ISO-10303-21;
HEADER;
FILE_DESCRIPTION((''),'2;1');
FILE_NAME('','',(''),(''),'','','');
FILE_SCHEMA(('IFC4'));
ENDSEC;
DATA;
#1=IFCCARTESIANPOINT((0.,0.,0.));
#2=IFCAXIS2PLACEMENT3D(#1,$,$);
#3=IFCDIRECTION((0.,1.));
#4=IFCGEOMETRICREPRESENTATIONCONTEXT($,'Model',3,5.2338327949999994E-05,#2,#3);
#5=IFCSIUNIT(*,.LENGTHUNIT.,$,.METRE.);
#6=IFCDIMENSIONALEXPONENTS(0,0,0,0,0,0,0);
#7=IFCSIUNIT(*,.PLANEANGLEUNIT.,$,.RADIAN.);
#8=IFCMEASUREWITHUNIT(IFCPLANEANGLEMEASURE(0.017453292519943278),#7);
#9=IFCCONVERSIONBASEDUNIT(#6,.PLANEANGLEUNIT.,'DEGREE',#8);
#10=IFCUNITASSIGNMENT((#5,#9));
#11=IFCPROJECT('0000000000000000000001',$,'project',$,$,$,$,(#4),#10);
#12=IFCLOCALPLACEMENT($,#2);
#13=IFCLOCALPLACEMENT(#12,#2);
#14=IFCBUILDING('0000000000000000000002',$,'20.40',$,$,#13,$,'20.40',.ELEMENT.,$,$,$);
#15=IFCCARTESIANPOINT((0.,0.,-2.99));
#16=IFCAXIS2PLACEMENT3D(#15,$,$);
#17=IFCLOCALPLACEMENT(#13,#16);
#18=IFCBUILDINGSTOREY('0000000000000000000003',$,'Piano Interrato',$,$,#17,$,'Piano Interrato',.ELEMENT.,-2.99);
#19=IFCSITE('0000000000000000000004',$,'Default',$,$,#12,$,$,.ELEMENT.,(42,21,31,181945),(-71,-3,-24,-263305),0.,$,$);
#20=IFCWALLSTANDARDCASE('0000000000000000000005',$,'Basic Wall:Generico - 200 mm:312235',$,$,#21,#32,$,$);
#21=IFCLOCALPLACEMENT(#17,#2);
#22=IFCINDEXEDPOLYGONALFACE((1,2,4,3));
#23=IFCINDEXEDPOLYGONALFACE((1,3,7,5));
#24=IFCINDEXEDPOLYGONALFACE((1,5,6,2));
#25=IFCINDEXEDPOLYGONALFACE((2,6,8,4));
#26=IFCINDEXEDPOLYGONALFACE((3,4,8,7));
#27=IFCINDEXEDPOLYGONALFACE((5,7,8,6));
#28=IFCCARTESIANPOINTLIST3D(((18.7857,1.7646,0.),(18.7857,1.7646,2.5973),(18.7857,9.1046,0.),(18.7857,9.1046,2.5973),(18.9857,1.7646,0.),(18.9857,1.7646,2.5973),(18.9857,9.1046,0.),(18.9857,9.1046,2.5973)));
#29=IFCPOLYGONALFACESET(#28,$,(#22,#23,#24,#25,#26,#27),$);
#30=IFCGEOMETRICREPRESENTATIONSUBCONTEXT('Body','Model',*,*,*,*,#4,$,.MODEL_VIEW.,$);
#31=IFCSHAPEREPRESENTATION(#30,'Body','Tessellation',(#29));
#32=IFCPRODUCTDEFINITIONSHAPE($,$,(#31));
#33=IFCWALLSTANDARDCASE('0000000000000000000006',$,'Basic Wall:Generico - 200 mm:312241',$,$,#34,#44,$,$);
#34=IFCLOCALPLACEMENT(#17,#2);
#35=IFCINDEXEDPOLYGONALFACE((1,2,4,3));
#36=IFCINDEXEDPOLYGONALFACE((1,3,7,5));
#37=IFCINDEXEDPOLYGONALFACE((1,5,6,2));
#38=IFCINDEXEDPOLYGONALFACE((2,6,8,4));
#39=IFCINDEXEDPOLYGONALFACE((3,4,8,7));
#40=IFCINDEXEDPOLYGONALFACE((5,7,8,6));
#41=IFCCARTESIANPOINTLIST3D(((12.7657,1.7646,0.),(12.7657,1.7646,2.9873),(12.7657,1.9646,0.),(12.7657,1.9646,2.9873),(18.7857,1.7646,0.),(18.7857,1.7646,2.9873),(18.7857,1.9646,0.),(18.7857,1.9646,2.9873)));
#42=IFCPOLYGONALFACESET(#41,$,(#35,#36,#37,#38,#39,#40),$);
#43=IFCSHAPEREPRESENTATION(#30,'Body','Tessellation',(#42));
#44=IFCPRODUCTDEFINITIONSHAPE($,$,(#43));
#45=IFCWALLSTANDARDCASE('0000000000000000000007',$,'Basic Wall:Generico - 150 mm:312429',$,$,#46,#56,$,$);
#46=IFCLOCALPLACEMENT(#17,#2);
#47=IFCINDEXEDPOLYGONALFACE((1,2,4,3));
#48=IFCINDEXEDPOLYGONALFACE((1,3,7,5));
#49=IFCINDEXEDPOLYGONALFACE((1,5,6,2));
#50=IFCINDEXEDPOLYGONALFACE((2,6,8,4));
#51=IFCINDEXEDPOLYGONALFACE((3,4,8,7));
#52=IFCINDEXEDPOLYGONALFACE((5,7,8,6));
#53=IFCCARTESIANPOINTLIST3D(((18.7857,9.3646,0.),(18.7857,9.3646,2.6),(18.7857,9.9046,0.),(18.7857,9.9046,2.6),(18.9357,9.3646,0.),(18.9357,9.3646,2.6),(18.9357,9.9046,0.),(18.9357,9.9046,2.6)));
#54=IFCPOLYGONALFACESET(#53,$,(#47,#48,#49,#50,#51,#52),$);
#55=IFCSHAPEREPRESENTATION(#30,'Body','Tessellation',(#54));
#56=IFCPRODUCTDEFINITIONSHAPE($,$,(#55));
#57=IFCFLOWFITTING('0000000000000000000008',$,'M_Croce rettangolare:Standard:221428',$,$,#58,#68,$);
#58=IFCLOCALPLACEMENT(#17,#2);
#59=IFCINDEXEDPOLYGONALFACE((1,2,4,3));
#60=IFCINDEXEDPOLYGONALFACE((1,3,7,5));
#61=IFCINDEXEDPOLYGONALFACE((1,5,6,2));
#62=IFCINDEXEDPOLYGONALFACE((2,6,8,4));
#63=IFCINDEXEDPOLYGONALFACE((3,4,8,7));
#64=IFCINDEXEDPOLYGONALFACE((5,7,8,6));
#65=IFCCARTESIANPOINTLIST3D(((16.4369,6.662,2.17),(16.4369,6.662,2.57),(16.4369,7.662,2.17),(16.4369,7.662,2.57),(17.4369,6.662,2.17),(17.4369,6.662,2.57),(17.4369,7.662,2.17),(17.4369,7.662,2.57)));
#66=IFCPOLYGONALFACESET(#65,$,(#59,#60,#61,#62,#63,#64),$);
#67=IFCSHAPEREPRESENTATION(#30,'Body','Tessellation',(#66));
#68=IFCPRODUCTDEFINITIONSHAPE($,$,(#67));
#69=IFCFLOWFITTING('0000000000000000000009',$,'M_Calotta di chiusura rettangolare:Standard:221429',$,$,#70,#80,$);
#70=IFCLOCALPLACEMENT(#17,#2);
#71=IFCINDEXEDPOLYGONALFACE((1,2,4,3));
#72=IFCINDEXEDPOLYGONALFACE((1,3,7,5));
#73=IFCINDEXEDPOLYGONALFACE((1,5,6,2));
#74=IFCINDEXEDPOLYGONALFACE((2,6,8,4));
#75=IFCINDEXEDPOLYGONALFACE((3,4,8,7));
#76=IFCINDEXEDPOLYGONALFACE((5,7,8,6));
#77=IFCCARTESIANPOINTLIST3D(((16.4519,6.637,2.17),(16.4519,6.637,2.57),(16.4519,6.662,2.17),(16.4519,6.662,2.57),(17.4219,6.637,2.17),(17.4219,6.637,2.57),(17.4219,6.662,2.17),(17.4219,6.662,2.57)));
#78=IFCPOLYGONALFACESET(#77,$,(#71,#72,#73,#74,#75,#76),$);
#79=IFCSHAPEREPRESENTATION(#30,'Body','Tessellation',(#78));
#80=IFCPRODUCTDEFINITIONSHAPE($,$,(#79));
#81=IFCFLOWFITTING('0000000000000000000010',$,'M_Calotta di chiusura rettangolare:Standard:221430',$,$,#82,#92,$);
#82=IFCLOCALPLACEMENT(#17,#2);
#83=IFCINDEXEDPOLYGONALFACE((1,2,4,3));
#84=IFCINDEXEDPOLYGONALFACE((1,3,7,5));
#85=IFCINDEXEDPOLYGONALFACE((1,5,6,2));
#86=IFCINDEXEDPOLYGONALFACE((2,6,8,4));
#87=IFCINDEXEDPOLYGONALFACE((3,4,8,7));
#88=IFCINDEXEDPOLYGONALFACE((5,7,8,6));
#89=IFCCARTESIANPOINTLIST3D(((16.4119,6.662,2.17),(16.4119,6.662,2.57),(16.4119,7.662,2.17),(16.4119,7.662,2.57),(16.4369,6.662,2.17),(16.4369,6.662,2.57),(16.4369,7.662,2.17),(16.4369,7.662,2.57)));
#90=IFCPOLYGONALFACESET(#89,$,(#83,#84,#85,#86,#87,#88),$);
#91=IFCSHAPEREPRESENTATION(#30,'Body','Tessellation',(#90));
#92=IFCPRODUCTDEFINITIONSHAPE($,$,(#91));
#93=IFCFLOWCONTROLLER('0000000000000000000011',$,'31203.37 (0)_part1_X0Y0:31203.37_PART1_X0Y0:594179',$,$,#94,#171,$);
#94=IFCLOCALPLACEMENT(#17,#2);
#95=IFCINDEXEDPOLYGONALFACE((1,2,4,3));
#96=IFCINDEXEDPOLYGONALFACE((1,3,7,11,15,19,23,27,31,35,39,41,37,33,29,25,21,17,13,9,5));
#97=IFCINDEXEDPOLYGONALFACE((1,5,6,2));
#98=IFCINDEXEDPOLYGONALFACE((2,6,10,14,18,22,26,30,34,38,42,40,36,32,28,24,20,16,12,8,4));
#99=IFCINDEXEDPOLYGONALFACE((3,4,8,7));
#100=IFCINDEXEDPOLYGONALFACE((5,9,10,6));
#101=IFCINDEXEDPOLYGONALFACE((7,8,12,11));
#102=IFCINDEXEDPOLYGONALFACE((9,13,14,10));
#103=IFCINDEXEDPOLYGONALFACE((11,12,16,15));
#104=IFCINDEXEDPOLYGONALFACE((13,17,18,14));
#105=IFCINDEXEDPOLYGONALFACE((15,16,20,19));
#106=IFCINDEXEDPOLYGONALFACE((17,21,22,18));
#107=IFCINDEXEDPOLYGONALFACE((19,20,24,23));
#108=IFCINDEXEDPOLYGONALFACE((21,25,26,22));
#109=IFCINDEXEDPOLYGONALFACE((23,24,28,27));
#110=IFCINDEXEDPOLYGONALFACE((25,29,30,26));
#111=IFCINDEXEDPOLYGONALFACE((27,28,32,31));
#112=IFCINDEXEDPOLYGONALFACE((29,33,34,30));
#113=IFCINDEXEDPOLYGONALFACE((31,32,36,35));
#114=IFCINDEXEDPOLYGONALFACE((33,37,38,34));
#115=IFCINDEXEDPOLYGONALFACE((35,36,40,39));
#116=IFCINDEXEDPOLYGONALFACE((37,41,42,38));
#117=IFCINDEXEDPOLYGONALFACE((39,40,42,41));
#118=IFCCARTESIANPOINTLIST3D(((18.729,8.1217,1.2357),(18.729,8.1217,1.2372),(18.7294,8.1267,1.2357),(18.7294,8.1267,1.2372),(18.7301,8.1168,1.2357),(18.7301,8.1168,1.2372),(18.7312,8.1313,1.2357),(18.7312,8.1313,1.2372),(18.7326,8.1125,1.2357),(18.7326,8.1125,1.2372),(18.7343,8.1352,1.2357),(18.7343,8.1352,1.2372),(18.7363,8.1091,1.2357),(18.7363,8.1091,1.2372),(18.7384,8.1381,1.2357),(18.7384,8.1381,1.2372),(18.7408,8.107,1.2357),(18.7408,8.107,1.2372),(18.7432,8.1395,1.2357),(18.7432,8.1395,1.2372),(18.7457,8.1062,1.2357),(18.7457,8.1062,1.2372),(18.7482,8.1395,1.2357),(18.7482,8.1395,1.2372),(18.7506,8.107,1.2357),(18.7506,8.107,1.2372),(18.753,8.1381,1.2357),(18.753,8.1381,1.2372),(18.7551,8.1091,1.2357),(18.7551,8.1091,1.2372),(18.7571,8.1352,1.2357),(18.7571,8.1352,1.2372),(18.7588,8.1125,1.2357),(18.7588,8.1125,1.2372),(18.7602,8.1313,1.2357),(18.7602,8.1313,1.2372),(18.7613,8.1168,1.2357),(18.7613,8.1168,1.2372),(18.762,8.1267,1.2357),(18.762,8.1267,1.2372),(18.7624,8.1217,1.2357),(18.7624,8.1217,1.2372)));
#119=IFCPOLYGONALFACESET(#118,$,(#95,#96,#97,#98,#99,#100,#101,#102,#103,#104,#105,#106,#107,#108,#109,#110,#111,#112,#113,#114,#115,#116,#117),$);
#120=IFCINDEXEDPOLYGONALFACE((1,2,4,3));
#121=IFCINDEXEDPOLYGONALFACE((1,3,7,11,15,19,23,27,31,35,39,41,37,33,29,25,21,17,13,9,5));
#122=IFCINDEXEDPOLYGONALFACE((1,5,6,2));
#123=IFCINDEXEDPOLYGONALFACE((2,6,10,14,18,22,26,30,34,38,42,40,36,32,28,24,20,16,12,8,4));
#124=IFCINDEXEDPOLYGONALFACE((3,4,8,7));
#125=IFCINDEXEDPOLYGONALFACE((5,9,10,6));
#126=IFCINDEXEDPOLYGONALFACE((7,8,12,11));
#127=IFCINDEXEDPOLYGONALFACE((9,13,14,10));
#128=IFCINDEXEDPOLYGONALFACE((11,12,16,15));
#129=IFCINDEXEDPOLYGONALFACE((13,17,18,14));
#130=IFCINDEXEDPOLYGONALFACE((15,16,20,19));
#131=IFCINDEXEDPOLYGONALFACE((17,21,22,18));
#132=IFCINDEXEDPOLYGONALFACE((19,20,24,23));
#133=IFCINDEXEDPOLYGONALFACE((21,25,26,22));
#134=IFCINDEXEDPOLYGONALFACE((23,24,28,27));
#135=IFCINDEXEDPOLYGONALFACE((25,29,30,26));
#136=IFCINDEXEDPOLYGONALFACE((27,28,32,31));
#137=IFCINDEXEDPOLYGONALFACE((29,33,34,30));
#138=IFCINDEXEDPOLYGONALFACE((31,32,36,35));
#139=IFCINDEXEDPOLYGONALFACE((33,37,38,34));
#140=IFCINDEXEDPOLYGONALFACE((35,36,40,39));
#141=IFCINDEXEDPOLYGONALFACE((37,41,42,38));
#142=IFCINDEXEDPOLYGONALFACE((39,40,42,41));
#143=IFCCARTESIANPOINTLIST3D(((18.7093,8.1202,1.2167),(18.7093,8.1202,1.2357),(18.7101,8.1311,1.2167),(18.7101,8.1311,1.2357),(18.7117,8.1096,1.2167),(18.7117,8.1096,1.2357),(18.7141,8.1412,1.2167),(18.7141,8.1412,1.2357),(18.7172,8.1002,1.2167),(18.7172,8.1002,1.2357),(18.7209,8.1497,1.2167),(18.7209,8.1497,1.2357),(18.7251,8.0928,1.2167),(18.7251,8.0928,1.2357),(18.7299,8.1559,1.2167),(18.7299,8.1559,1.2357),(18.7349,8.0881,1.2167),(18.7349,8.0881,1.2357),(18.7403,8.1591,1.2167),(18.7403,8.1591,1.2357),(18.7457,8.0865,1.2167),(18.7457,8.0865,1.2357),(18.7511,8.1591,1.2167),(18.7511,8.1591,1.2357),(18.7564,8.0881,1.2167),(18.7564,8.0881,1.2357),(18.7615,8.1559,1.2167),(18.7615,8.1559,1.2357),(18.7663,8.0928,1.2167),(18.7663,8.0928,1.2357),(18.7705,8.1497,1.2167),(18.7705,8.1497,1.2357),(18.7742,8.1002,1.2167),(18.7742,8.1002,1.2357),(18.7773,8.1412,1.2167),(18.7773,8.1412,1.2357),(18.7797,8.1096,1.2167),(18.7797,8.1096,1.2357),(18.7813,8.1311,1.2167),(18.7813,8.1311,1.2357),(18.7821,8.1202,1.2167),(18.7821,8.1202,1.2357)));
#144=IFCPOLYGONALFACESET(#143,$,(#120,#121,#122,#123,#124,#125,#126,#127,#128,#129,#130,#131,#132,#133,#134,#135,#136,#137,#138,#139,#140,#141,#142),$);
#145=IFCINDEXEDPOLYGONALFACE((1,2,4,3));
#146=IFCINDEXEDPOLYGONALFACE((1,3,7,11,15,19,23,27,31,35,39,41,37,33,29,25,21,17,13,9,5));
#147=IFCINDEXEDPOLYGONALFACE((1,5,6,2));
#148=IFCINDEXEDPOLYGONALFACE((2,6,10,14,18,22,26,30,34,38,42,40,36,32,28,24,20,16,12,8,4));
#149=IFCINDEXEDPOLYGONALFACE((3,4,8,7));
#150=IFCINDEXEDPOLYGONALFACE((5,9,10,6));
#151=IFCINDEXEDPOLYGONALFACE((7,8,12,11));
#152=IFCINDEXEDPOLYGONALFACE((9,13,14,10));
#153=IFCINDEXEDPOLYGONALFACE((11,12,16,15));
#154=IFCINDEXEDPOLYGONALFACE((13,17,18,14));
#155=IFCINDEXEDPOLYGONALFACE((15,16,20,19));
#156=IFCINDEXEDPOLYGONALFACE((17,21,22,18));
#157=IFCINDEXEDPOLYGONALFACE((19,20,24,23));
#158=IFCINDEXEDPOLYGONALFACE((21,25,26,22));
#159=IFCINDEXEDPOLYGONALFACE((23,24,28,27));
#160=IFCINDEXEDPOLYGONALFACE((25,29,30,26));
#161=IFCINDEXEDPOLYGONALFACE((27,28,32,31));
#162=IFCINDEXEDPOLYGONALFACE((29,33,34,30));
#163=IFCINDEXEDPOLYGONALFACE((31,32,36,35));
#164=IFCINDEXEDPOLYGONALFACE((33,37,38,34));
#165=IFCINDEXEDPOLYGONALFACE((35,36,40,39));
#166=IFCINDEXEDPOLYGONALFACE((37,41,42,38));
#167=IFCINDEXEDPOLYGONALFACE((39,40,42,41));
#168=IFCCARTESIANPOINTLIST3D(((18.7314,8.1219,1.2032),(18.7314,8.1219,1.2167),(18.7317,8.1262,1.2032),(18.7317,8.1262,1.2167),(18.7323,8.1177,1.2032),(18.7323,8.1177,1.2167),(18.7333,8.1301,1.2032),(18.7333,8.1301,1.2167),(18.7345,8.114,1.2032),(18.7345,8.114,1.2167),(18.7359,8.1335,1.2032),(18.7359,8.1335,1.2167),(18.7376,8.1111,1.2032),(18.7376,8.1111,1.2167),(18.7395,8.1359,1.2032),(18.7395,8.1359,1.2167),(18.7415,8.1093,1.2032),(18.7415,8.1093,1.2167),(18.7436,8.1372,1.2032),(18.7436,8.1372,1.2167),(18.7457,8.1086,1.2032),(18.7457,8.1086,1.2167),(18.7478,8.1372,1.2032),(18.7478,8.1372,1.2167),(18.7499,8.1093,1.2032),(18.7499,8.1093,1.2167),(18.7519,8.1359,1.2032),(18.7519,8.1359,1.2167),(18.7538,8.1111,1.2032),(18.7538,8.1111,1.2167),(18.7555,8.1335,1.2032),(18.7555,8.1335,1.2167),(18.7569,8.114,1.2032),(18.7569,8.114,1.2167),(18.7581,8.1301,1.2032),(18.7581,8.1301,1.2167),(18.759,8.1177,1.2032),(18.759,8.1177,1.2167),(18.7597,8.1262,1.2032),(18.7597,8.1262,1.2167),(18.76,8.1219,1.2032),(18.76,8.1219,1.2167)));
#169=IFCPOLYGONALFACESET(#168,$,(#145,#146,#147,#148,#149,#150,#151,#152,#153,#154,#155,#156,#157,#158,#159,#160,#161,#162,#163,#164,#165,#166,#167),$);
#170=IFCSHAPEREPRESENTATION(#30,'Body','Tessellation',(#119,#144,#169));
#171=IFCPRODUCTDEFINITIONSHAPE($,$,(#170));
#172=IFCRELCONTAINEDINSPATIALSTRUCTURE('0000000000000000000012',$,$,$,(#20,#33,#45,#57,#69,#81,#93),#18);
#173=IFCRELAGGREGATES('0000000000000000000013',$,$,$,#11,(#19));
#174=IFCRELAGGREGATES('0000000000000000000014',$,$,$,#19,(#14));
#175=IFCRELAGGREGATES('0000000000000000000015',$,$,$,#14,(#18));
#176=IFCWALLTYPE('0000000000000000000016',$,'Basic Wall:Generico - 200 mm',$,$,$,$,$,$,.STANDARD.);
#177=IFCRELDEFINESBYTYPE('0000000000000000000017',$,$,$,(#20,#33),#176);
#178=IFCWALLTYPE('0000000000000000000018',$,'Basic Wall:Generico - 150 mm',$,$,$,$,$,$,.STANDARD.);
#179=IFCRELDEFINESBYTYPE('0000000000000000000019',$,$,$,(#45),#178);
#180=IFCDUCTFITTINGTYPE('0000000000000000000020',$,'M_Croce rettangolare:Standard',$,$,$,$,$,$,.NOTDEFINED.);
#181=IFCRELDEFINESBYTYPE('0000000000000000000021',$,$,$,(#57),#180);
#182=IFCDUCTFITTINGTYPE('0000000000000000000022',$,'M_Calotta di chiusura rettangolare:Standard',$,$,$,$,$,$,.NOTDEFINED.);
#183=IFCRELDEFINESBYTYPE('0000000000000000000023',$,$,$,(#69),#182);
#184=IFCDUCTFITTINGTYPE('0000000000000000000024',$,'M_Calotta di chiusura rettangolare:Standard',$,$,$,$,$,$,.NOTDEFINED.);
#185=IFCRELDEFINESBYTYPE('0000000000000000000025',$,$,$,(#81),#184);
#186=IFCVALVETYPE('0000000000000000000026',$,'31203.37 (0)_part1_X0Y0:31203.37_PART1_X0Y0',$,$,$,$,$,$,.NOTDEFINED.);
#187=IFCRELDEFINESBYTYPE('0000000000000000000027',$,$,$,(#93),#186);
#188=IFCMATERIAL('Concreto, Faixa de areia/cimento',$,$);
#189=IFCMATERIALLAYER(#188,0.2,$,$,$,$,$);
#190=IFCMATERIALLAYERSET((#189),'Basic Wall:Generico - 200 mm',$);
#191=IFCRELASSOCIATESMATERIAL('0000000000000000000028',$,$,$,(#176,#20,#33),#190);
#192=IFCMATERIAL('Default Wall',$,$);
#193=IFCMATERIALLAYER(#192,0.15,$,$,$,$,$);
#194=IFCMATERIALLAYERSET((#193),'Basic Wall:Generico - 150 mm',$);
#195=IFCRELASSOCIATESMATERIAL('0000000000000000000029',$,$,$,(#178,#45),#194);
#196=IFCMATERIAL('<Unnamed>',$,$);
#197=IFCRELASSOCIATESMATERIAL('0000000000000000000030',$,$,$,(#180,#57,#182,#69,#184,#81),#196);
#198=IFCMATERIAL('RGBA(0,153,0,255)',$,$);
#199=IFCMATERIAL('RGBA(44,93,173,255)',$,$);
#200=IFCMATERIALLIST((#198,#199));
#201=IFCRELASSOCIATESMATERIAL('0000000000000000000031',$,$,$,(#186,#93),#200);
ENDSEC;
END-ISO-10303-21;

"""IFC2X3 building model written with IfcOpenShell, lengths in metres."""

from ifc_helpers import new_model, entity, si_unit, converted_unit, direction, frame, frame_2d, origin, place, context, subcontext, project, spatial, rectangle, circle, extrude, source, transform, mapped, material, material_list, layer, layer_set, layer_usage, type_object, type_shapes, element, save


model = new_model("IFC2X3")

# Units and contexts
model_context = context("Model", 3, precision=5.2338327949999994e-05, world=origin(), true_north=direction((0.0, 1.0)))
body_context = subcontext(model_context, "Body", "Model", "MODEL_VIEW")
ifc_project = project(units=[si_unit("LENGTHUNIT", "METRE"), converted_unit("PLANEANGLEUNIT", "DEGREE", entity("IfcPlaneAngleMeasure", 0.017453292519943278), si_unit("PLANEANGLEUNIT", "RADIAN"), dimensions=[0, 0, 0, 0, 0, 0, 0])], contexts=[model_context])

# Site, building, storey
site_placement = place(None, origin())
site = spatial("IfcSite", under=ifc_project, at=site_placement, Name="Default", CompositionType="ELEMENT", RefLatitude=(42, 21, 31, 181945), RefLongitude=(-71, -3, -24, -263305), RefElevation=0.0)
building_placement = place(site_placement, origin())
building = spatial("IfcBuilding", under=site, at=building_placement, Name="20.40", LongName="20.40", CompositionType="ELEMENT")
storey_placement = place(building_placement, frame((0.0, 0.0, -2.99)))
storey = spatial("IfcBuildingStorey", under=building, at=storey_placement, Name="Piano Interrato", LongName="Piano Interrato", CompositionType="ELEMENT", Elevation=-2.99)

# Walls
ifc_material_1 = material(Name="Concreto, Faixa de areia/cimento")
ifc_layer_1 = layer(ifc_material_1, 0.2)
ifc_layer_set_1 = layer_set([ifc_layer_1], Name="Basic Wall:Generico - 200 mm")
ifc_layer_usage_1 = layer_usage(ifc_layer_set_1, "AXIS2", "NEGATIVE", 0.1)
wall_type_1 = type_object("IfcWallType", Name="Basic Wall:Generico - 200 mm", PredefinedType="STANDARD", material=ifc_layer_set_1)
wall_1_placement = place(storey_placement, frame((18.8857, 9.1046, 0.0), z_axis=(0.0, 0.0, 1.0), x_axis=(0.0, -1.0, 0.0)))
element("IfcWallStandardCase", 1, at=wall_1_placement, inside=storey, type_object=wall_type_1, material=ifc_layer_usage_1, Name="Basic Wall:Generico - 200 mm:312235", context=body_context, shape_type="SweptSolid", body=[
    extrude(rectangle(XDim=7.34, YDim=0.2, at=frame_2d((3.67, 0.0), x_axis=(-1.0, 0.0))), origin(), (0.0, 0.0, 1.0), 2.5973),
])
ifc_layer_usage_2 = layer_usage(ifc_layer_set_1, "AXIS2", "NEGATIVE", 0.1)
wall_2_placement = place(storey_placement, frame((18.7857, 1.8646, 0.0), z_axis=(0.0, 0.0, 1.0), x_axis=(-1.0, 0.0, 0.0)))
element("IfcWallStandardCase", 2, at=wall_2_placement, inside=storey, type_object=wall_type_1, material=ifc_layer_usage_2, Name="Basic Wall:Generico - 200 mm:312241", context=body_context, shape_type="SweptSolid", body=[
    extrude(rectangle(XDim=6.02, YDim=0.2, at=frame_2d((3.01, 0.0), x_axis=(-1.0, 0.0))), origin(), (0.0, 0.0, 1.0), 2.9873),
])
ifc_material_2 = material(Name="Default Wall")
ifc_layer_2 = layer(ifc_material_2, 0.15)
ifc_layer_set_2 = layer_set([ifc_layer_2], Name="Basic Wall:Generico - 150 mm")
ifc_layer_usage_3 = layer_usage(ifc_layer_set_2, "AXIS2", "NEGATIVE", 0.075)
wall_type_2 = type_object("IfcWallType", Name="Basic Wall:Generico - 150 mm", PredefinedType="STANDARD", material=ifc_layer_set_2)
wall_3_placement = place(storey_placement, frame((18.8607, 9.9046, 0.0), z_axis=(0.0, 0.0, 1.0), x_axis=(0.0, -1.0, 0.0)))
element("IfcWallStandardCase", 3, at=wall_3_placement, inside=storey, type_object=wall_type_2, material=ifc_layer_usage_3, Name="Basic Wall:Generico - 150 mm:312429", context=body_context, shape_type="SweptSolid", body=[
    extrude(rectangle(XDim=0.54, YDim=0.15, at=frame_2d((0.27, 0.0), x_axis=(-1.0, 0.0))), origin(), (0.0, 0.0, 1.0), 2.6),
])

# Flow fittings
ifc_material_3 = material(Name="<Unnamed>")
duct_fitting_type_1 = type_object("IfcDuctFittingType", Name="M_Croce rettangolare:Standard", PredefinedType="NOTDEFINED", material=ifc_material_3)
shared_shape_1 = source(origin(), body_context, "Body", "SweptSolid", [
    extrude(rectangle(XDim=1.0, YDim=1.0, at=frame_2d((0.0, 0.0), x_axis=(1.0, 0.0))), frame((0.0, 0.0, -0.2), z_axis=(0.0, 0.0, 1.0), x_axis=(0.0, 1.0, 0.0)), (0.0, 0.0, 1.0), 0.4),
])
type_shapes(duct_fitting_type_1, [shared_shape_1])
flow_fitting_1_placement = place(storey_placement, frame((16.9369, 7.162, 2.37), z_axis=(0.0, 0.0, -1.0), x_axis=(-1.0, 0.0, 0.0)))
element("IfcFlowFitting", 4, at=flow_fitting_1_placement, inside=storey, type_object=duct_fitting_type_1, material=ifc_material_3, Name="M_Croce rettangolare:Standard:221428", context=body_context, shape_type="MappedRepresentation", body=[
    mapped(shared_shape_1, transform((0.0, 0.0, 0.0), scale=1.0)),
])
duct_fitting_type_2 = type_object("IfcDuctFittingType", Name="M_Calotta di chiusura rettangolare:Standard", PredefinedType="NOTDEFINED", material=ifc_material_3)
shared_shape_2 = source(origin(), body_context, "Body", "SweptSolid", [
    extrude(rectangle(XDim=0.025, YDim=0.97, at=frame_2d((0.0, 0.0), x_axis=(1.0, 0.0))), frame((0.0125, 0.0, -0.2)), (0.0, 0.0, 1.0), 0.4),
])
type_shapes(duct_fitting_type_2, [shared_shape_2])
flow_fitting_2_placement = place(storey_placement, frame((16.9369, 6.662, 2.37), z_axis=(0.0, 0.0, 1.0), x_axis=(0.0, -1.0, 0.0)))
element("IfcFlowFitting", 5, at=flow_fitting_2_placement, inside=storey, type_object=duct_fitting_type_2, material=ifc_material_3, Name="M_Calotta di chiusura rettangolare:Standard:221429", context=body_context, shape_type="MappedRepresentation", body=[
    mapped(shared_shape_2, transform((0.0, 0.0, 0.0), scale=1.0)),
])
duct_fitting_type_3 = type_object("IfcDuctFittingType", Name="M_Calotta di chiusura rettangolare:Standard", PredefinedType="NOTDEFINED", material=ifc_material_3)
shared_shape_3 = source(origin(), body_context, "Body", "SweptSolid", [
    extrude(rectangle(XDim=0.025, YDim=1.0, at=frame_2d((0.0, 0.0), x_axis=(1.0, 0.0))), frame((0.0125, 0.0, -0.2)), (0.0, 0.0, 1.0), 0.4),
])
type_shapes(duct_fitting_type_3, [shared_shape_3])
flow_fitting_3_placement = place(storey_placement, frame((16.4369, 7.162, 2.37), z_axis=(0.0, 0.0, 1.0), x_axis=(-1.0, 0.0, 0.0)))
element("IfcFlowFitting", 6, at=flow_fitting_3_placement, inside=storey, type_object=duct_fitting_type_3, material=ifc_material_3, Name="M_Calotta di chiusura rettangolare:Standard:221430", context=body_context, shape_type="MappedRepresentation", body=[
    mapped(shared_shape_3, transform((0.0, 0.0, 0.0), scale=1.0)),
])

# Flow controller
ifc_material_4 = material(Name="RGBA(0,153,0,255)")
ifc_material_5 = material(Name="RGBA(44,93,173,255)")
ifc_material_list_1 = material_list([ifc_material_4, ifc_material_5])
valve_type_1 = type_object("IfcValveType", Name="31203.37 (0)_part1_X0Y0:31203.37_PART1_X0Y0", PredefinedType="NOTDEFINED", material=ifc_material_list_1)
shared_shape_4 = source(origin(), body_context, "Body", "SweptSolid", [
    extrude(circle(Radius=0.0168, at=frame_2d((0.0, 0.0), x_axis=(1.0, 0.0))), frame((0.0, 0.0, 0.0325), z_axis=(0.0, 0.0, 1.0), x_axis=(0.0, -1.0, 0.0)), (0.0, 0.0, 1.0), 0.0015),
    extrude(circle(Radius=0.0365, at=frame_2d((0.0, 0.0), x_axis=(1.0, 0.0))), frame((0.0, 0.0, 0.0135), z_axis=(0.0, 0.0, 1.0), x_axis=(0.0, -1.0, 0.0)), (0.0, 0.0, 1.0), 0.019),
    extrude(circle(Radius=0.0144, at=frame_2d((0.0, 0.0), x_axis=(1.0, 0.0))), frame((0.0, 0.0, 0.0), z_axis=(0.0, 0.0, 1.0), x_axis=(0.0, -1.0, 0.0)), (0.0, 0.0, 1.0), 0.0135),
])
type_shapes(valve_type_1, [shared_shape_4])
flow_controller_1_placement = place(storey_placement, frame((18.7457, 8.123, 1.2032)))
element("IfcFlowController", 7, at=flow_controller_1_placement, inside=storey, type_object=valve_type_1, material=ifc_material_list_1, Name="31203.37 (0)_part1_X0Y0:31203.37_PART1_X0Y0:594179", context=body_context, shape_type="MappedRepresentation", body=[
    mapped(shared_shape_4, transform((0.0, 0.0, 0.0), scale=1.0)),
])

save(model, "model.ifc")
